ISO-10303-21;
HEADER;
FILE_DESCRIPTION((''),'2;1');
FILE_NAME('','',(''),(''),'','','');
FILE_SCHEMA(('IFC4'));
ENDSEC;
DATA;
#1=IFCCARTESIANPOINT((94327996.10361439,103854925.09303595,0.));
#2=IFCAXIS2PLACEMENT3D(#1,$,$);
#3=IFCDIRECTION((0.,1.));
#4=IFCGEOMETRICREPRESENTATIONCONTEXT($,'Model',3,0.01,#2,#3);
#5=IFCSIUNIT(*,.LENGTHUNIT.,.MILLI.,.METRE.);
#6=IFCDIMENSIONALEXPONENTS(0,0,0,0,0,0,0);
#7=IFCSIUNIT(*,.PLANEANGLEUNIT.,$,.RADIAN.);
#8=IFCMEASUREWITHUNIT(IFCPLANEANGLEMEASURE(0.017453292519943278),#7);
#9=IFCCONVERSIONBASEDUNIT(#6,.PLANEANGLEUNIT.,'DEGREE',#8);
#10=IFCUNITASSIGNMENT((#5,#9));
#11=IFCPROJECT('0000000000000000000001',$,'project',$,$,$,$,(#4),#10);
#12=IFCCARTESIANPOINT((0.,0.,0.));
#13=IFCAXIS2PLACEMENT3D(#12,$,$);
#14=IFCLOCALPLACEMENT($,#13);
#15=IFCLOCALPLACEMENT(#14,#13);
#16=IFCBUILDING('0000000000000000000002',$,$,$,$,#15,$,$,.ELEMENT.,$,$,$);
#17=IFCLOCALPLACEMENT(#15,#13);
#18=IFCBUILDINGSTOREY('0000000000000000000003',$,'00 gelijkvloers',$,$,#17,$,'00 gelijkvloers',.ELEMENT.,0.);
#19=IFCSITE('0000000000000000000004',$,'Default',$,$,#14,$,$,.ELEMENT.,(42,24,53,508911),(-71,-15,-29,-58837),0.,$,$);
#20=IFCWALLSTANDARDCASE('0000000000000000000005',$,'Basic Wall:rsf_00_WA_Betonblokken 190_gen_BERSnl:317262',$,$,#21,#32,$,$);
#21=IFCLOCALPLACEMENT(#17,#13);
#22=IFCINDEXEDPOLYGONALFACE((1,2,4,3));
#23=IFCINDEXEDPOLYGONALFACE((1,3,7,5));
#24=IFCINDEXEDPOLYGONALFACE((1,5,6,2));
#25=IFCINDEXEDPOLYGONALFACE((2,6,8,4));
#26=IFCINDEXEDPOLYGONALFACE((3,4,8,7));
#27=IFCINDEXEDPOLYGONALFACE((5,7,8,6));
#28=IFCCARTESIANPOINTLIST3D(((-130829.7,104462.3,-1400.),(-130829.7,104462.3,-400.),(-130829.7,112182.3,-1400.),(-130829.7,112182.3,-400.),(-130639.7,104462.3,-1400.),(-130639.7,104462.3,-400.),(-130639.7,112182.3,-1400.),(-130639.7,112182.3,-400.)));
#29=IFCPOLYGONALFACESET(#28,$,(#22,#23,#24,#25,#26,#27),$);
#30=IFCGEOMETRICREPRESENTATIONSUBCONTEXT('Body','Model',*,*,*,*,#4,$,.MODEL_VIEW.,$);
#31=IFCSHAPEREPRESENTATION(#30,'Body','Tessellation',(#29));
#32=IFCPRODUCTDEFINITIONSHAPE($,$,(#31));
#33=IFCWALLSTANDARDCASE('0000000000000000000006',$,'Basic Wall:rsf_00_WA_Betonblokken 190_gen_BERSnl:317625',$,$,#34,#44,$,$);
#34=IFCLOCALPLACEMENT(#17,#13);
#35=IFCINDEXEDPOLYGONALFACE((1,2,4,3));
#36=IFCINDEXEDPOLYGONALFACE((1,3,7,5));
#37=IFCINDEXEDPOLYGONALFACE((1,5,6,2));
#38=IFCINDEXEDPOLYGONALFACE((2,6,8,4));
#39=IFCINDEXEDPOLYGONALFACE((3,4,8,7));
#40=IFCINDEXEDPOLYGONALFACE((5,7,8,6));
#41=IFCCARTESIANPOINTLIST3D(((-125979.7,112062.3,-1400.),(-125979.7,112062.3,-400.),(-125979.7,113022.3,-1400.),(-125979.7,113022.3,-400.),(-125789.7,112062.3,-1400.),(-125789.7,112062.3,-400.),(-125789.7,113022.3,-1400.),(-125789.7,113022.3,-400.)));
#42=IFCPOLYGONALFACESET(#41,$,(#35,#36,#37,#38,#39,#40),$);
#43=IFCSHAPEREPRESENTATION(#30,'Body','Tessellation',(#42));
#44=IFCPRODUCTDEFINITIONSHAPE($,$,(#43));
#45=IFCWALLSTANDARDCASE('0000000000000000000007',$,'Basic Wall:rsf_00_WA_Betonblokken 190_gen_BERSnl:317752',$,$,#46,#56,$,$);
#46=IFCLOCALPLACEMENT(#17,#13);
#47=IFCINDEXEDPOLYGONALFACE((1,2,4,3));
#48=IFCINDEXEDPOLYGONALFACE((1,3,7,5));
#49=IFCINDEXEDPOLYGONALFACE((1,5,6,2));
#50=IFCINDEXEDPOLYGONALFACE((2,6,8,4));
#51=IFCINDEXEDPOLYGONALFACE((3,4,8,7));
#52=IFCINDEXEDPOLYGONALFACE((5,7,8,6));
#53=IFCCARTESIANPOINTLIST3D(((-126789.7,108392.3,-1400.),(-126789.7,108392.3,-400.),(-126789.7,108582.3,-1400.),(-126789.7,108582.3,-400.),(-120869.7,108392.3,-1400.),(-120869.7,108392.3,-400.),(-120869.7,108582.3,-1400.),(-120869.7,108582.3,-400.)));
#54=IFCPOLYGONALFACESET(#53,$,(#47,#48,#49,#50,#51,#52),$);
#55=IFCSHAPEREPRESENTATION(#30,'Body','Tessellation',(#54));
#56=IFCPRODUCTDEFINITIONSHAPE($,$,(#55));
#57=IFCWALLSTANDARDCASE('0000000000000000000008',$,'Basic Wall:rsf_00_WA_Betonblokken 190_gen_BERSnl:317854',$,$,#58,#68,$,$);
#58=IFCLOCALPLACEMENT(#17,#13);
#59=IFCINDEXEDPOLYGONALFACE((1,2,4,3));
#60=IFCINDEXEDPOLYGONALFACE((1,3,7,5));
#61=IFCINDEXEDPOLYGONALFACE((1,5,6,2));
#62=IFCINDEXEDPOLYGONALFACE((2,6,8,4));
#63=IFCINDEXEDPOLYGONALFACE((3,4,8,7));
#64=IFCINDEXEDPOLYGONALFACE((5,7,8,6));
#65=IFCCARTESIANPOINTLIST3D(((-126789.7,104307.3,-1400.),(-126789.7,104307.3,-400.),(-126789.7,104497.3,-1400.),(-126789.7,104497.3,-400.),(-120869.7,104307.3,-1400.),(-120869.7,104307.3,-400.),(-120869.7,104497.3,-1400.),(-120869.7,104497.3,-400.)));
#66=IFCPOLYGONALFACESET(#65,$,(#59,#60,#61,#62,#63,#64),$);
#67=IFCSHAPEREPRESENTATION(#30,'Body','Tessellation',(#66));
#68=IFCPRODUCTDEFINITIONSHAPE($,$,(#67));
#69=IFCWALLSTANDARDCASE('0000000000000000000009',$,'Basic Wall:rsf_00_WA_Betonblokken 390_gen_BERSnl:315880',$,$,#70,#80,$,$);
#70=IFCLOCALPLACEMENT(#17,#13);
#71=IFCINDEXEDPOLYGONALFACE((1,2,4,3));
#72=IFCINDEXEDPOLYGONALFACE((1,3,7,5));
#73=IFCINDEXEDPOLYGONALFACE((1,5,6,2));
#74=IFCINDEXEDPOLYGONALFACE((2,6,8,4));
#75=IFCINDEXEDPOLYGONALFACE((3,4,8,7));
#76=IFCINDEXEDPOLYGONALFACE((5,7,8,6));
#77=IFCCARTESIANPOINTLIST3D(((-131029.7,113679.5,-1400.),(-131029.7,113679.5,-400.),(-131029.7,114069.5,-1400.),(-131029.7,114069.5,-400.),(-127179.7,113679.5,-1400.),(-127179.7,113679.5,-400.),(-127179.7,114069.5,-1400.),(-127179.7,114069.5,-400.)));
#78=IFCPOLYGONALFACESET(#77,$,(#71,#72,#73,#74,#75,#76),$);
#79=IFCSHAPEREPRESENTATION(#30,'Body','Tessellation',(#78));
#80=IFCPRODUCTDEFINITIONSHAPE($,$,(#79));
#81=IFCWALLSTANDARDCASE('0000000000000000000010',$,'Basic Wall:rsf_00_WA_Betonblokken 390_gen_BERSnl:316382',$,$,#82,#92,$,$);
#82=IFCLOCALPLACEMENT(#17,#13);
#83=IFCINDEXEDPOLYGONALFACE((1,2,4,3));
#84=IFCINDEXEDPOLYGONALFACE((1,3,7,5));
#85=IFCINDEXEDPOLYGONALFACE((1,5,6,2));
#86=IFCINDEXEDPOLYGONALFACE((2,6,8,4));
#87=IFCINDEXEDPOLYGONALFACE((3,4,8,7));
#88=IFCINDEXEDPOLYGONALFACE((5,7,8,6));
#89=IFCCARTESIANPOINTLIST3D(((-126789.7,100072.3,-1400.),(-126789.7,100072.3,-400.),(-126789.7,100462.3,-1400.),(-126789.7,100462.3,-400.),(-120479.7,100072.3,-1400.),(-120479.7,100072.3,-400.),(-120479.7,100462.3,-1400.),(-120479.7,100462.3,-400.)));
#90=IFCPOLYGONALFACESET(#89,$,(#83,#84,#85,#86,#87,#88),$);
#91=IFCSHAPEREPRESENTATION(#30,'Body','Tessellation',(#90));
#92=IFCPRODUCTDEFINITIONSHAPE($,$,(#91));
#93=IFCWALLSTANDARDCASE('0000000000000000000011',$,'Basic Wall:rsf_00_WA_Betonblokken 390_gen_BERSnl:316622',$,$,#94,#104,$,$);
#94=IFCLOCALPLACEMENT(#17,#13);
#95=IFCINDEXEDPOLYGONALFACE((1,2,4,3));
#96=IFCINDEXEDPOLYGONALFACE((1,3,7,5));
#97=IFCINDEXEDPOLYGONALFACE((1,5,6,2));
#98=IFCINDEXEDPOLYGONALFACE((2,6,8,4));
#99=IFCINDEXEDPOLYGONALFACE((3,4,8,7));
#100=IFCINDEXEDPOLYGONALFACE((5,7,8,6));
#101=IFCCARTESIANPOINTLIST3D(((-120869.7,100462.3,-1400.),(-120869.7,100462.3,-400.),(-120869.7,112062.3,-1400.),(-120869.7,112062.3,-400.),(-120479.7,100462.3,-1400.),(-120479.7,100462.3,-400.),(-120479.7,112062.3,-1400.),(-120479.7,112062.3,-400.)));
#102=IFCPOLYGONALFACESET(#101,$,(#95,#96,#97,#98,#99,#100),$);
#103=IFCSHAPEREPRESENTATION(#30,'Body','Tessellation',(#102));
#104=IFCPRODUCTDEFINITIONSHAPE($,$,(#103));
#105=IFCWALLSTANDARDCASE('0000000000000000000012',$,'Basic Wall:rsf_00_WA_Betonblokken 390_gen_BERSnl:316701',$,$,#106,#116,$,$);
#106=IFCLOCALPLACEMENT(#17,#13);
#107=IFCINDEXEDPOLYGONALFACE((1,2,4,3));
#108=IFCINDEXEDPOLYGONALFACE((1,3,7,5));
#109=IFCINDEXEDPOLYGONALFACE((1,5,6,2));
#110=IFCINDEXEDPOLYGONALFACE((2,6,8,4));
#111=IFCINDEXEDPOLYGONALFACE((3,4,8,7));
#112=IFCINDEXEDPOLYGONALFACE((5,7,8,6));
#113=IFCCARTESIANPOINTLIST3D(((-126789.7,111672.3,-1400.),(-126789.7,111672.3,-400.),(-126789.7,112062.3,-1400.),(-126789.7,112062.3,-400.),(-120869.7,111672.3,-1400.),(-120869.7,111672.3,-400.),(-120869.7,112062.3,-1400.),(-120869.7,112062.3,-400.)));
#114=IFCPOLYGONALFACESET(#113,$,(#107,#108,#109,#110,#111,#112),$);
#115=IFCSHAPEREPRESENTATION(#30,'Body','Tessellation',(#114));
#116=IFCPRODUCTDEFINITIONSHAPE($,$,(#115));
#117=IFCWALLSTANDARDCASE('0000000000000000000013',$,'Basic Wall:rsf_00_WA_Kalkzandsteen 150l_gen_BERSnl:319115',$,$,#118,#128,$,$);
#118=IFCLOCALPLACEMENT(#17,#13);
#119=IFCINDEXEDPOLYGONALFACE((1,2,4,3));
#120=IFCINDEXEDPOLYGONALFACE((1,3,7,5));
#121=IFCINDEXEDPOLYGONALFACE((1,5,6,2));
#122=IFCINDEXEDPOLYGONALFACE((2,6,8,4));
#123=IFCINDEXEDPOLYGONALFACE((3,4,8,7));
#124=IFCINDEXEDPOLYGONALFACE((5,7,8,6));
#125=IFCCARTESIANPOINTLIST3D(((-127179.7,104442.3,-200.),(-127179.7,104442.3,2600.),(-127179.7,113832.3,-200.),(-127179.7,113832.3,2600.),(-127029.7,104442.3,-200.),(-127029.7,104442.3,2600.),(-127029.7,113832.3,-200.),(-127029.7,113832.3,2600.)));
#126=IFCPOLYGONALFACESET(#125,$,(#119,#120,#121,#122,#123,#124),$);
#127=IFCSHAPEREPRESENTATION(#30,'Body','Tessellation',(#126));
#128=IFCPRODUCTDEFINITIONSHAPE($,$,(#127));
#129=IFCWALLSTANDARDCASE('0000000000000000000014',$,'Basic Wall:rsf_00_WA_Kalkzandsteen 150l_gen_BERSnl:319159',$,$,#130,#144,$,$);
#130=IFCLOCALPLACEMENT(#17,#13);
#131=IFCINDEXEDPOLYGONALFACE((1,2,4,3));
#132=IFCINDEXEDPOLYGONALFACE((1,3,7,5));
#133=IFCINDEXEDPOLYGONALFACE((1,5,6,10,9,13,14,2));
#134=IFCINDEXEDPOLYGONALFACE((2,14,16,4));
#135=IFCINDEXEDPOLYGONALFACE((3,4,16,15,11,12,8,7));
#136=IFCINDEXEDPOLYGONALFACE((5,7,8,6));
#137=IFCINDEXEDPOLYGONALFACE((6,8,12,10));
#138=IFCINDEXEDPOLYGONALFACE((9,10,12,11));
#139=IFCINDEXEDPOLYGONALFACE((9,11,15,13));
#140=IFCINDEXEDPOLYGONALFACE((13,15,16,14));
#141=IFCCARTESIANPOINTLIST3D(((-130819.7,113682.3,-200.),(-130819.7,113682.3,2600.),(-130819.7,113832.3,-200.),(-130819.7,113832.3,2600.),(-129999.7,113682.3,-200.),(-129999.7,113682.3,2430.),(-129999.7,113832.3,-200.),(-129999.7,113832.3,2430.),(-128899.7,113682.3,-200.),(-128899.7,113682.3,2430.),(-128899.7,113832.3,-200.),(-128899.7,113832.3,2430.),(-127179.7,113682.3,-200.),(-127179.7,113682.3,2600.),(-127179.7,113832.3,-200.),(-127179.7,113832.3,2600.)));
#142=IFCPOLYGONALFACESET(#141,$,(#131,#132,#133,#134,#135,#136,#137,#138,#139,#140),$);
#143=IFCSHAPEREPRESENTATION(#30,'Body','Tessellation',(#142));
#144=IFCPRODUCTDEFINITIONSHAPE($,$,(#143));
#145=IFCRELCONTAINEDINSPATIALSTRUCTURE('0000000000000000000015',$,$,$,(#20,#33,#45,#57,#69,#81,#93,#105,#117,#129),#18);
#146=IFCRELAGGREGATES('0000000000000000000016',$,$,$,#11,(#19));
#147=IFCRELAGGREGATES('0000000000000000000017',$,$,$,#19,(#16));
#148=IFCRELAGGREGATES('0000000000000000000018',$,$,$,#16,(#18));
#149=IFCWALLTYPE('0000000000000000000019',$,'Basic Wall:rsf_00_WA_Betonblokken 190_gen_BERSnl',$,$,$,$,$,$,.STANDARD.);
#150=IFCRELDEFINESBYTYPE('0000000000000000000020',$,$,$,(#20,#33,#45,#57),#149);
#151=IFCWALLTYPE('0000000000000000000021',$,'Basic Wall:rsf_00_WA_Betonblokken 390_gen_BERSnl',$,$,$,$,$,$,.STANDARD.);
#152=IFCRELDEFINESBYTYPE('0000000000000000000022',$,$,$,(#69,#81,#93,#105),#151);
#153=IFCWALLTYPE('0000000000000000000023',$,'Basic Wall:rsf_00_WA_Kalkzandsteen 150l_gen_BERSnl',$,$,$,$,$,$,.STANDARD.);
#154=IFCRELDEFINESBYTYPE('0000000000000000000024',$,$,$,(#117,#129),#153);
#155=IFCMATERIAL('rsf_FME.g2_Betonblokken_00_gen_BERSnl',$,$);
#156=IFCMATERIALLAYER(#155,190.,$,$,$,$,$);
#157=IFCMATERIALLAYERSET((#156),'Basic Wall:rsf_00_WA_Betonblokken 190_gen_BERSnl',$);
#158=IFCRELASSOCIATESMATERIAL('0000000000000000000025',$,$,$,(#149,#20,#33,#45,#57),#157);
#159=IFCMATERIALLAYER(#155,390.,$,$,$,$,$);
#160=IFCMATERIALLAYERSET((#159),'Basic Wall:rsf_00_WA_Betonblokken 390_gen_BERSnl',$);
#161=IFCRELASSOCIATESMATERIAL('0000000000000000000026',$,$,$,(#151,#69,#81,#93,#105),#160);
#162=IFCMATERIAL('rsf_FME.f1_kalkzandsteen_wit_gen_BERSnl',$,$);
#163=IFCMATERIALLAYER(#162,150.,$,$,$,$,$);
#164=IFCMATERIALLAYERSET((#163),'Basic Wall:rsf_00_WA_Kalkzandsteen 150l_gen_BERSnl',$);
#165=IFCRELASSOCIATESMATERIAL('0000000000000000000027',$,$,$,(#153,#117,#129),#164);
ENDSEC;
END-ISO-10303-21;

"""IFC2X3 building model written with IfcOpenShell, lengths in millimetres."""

from ifc_helpers import new_model, entity, si_unit, converted_unit, direction, frame, frame_2d, origin, place, context, subcontext, project, spatial, polyline, rectangle, extrude, clip, bounded_halfspace, material, layer, layer_set, layer_usage, type_object, element, save


model = new_model("IFC2X3")

# Units and contexts
model_context = context("Model", 3, precision=0.01, world=frame((94327996.10361439, 103854925.09303595, 0.0)), true_north=direction((0.0, 1.0)))
body_context = subcontext(model_context, "Body", "Model", "MODEL_VIEW")
ifc_project = project(units=[si_unit("LENGTHUNIT", "METRE", prefix="MILLI"), converted_unit("PLANEANGLEUNIT", "DEGREE", entity("IfcPlaneAngleMeasure", 0.017453292519943278), si_unit("PLANEANGLEUNIT", "RADIAN"), dimensions=[0, 0, 0, 0, 0, 0, 0])], contexts=[model_context])

# Site, building, storey
site_placement = place(None, origin())
site = spatial("IfcSite", under=ifc_project, at=site_placement, Name="Default", CompositionType="ELEMENT", RefLatitude=(42, 24, 53, 508911), RefLongitude=(-71, -15, -29, -58837), RefElevation=0.0)
building_placement = place(site_placement, origin())
building = spatial("IfcBuilding", under=site, at=building_placement, CompositionType="ELEMENT")
storey_placement = place(building_placement, origin())
storey = spatial("IfcBuildingStorey", under=building, at=storey_placement, Name="00 gelijkvloers", LongName="00 gelijkvloers", CompositionType="ELEMENT", Elevation=0.0)

# Walls
ifc_material_1 = material(Name="rsf_FME.g2_Betonblokken_00_gen_BERSnl")
ifc_layer_1 = layer(ifc_material_1, 190.0)
ifc_layer_set_1 = layer_set([ifc_layer_1], Name="Basic Wall:rsf_00_WA_Betonblokken 190_gen_BERSnl")
ifc_layer_usage_1 = layer_usage(ifc_layer_set_1, "AXIS2", "POSITIVE", -95.0)
wall_type_1 = type_object("IfcWallType", Name="Basic Wall:rsf_00_WA_Betonblokken 190_gen_BERSnl", PredefinedType="STANDARD", material=ifc_layer_set_1)
wall_1_placement = place(storey_placement, frame((-130734.7, 104462.3, -1400.0), z_axis=(0.0, 0.0, 1.0), x_axis=(0.0, 1.0, 0.0)))
element("IfcWallStandardCase", 1, at=wall_1_placement, inside=storey, type_object=wall_type_1, material=ifc_layer_usage_1, Name="Basic Wall:rsf_00_WA_Betonblokken 190_gen_BERSnl:317262", context=body_context, shape_type="Clipping", body=[
    clip(extrude(rectangle(XDim=7720.0, YDim=190.0, at=frame_2d((3860.0, 0.0), x_axis=(-1.0, 0.0))), origin(), (0.0, 0.0, 1.0), 1000.0), bounded_halfspace(frame((0.0, -95.0, 1000.0), z_axis=(0.0, 0.0, -1.0), x_axis=(1.0, 0.0, 0.0)), True, frame((0.0, -95.0, 1000.0)), polyline([(0.0, 0.0), (7720.0, 0.0), (7720.0, 190.0), (0.0, 190.0), (0.0, 0.0)]))),
])
ifc_layer_usage_2 = layer_usage(ifc_layer_set_1, "AXIS2", "POSITIVE", -95.0)
wall_2_placement = place(storey_placement, frame((-125884.7, 112062.3, -1400.0), z_axis=(0.0, 0.0, 1.0), x_axis=(0.0, 1.0, 0.0)))
element("IfcWallStandardCase", 2, at=wall_2_placement, inside=storey, type_object=wall_type_1, material=ifc_layer_usage_2, Name="Basic Wall:rsf_00_WA_Betonblokken 190_gen_BERSnl:317625", context=body_context, shape_type="Clipping", body=[
    clip(extrude(rectangle(XDim=960.0, YDim=190.0, at=frame_2d((480.0, 0.0), x_axis=(-1.0, 0.0))), origin(), (0.0, 0.0, 1.0), 1000.0), bounded_halfspace(frame((0.0, -95.0, 1000.0), z_axis=(0.0, 0.0, -1.0), x_axis=(1.0, 0.0, 0.0)), True, frame((0.0, -95.0, 1000.0)), polyline([(0.0, 0.0), (960.0, 0.0), (960.0, 190.0), (0.0, 190.0), (0.0, 0.0)]))),
])
ifc_layer_usage_3 = layer_usage(ifc_layer_set_1, "AXIS2", "NEGATIVE", 95.0)
wall_3_placement = place(storey_placement, frame((-126789.7, 108487.3, -1400.0)))
element("IfcWallStandardCase", 3, at=wall_3_placement, inside=storey, type_object=wall_type_1, material=ifc_layer_usage_3, Name="Basic Wall:rsf_00_WA_Betonblokken 190_gen_BERSnl:317752", context=body_context, shape_type="Clipping", body=[
    clip(extrude(rectangle(XDim=5920.0, YDim=190.0, at=frame_2d((2960.0, 0.0), x_axis=(-1.0, 0.0))), origin(), (0.0, 0.0, 1.0), 1000.0), bounded_halfspace(frame((0.0, -95.0, 1000.0), z_axis=(0.0, 0.0, -1.0), x_axis=(0.0, 1.0, 0.0)), True, frame((0.0, -95.0, 1000.0)), polyline([(0.0, 0.0), (5920.0, 0.0), (5920.0, 190.0), (0.0, 190.0), (0.0, 0.0)]))),
])
ifc_layer_usage_4 = layer_usage(ifc_layer_set_1, "AXIS2", "NEGATIVE", 95.0)
wall_4_placement = place(storey_placement, frame((-126789.7, 104402.3, -1400.0)))
element("IfcWallStandardCase", 4, at=wall_4_placement, inside=storey, type_object=wall_type_1, material=ifc_layer_usage_4, Name="Basic Wall:rsf_00_WA_Betonblokken 190_gen_BERSnl:317854", context=body_context, shape_type="Clipping", body=[
    clip(extrude(rectangle(XDim=5920.0, YDim=190.0, at=frame_2d((2960.0, 0.0), x_axis=(-1.0, 0.0))), origin(), (0.0, 0.0, 1.0), 1000.0), bounded_halfspace(frame((0.0, -95.0, 1000.0), z_axis=(0.0, 0.0, -1.0), x_axis=(0.0, 1.0, 0.0)), True, frame((0.0, -95.0, 1000.0)), polyline([(0.0, 0.0), (5920.0, 0.0), (5920.0, 190.0), (0.0, 190.0), (0.0, 0.0)]))),
])
ifc_layer_2 = layer(ifc_material_1, 390.0)
ifc_layer_set_2 = layer_set([ifc_layer_2], Name="Basic Wall:rsf_00_WA_Betonblokken 390_gen_BERSnl")
wall_type_2 = type_object("IfcWallType", Name="Basic Wall:rsf_00_WA_Betonblokken 390_gen_BERSnl", PredefinedType="STANDARD", material=ifc_layer_set_2)
ifc_layer_usage_5 = layer_usage(ifc_layer_set_2, "AXIS2", "POSITIVE", -195.0)
wall_5_placement = place(storey_placement, frame((-127179.7, 113874.5, -1400.0), z_axis=(0.0, 0.0, 1.0), x_axis=(-1.0, 0.0, 0.0)))
element("IfcWallStandardCase", 5, at=wall_5_placement, inside=storey, type_object=wall_type_2, material=ifc_layer_usage_5, Name="Basic Wall:rsf_00_WA_Betonblokken 390_gen_BERSnl:315880", context=body_context, shape_type="Clipping", body=[
    clip(extrude(rectangle(XDim=3850.0, YDim=390.0, at=frame_2d((1925.0, 0.0), x_axis=(-1.0, 0.0))), origin(), (0.0, 0.0, 1.0), 1000.0), bounded_halfspace(frame((0.0, -195.0, 1000.0), z_axis=(0.0, 0.0, -1.0), x_axis=(0.0, -1.0, 0.0)), True, frame((0.0, -195.0, 1000.0)), polyline([(0.0, 0.0), (3660.0, 0.0), (3850.0, 0.0), (3850.0, 390.0), (3460.0, 390.0), (0.0, 390.0), (0.0, 0.0)]))),
])
ifc_layer_usage_6 = layer_usage(ifc_layer_set_2, "AXIS2", "NEGATIVE", 195.0)
wall_6_placement = place(storey_placement, frame((-126789.7, 100267.3, -1400.0)))
element("IfcWallStandardCase", 6, at=wall_6_placement, inside=storey, type_object=wall_type_2, material=ifc_layer_usage_6, Name="Basic Wall:rsf_00_WA_Betonblokken 390_gen_BERSnl:316382", context=body_context, shape_type="Clipping", body=[
    clip(extrude(rectangle(XDim=6310.0, YDim=390.0, at=frame_2d((3155.0, 0.0), x_axis=(-1.0, 0.0))), origin(), (0.0, 0.0, 1.0), 1000.0), bounded_halfspace(frame((0.0, -195.0, 1000.0), z_axis=(0.0, 0.0, -1.0), x_axis=(0.0, 1.0, 0.0)), True, frame((0.0, -195.0, 1000.0)), polyline([(0.0, 0.0), (6310.0, 0.0), (6310.0, 390.0), (5920.0, 390.0), (0.0, 390.0), (0.0, 0.0)]))),
])
ifc_layer_usage_7 = layer_usage(ifc_layer_set_2, "AXIS2", "POSITIVE", -195.0)
wall_7_placement = place(storey_placement, frame((-120674.7, 100462.3, -1400.0), z_axis=(0.0, 0.0, 1.0), x_axis=(0.0, 1.0, 0.0)))
element("IfcWallStandardCase", 7, at=wall_7_placement, inside=storey, type_object=wall_type_2, material=ifc_layer_usage_7, Name="Basic Wall:rsf_00_WA_Betonblokken 390_gen_BERSnl:316622", context=body_context, shape_type="Clipping", body=[
    clip(extrude(rectangle(XDim=11600.0, YDim=390.0, at=frame_2d((5800.0, 0.0), x_axis=(-1.0, 0.0))), origin(), (0.0, 0.0, 1.0), 1000.0), bounded_halfspace(frame((0.0, -195.0, 1000.0), z_axis=(0.0, 0.0, -1.0), x_axis=(1.0, 0.0, 0.0)), True, frame((0.0, -195.0, 1000.0)), polyline([(0.0, 0.0), (11600.0, 0.0), (11600.0, 390.0), (11210.0, 390.0), (8120.0, 390.0), (7930.0, 390.0), (4035.0, 390.0), (3845.0, 390.0), (0.0, 390.0), (0.0, 0.0)]))),
])
ifc_layer_usage_8 = layer_usage(ifc_layer_set_2, "AXIS2", "POSITIVE", -195.0)
wall_8_placement = place(storey_placement, frame((-120869.7, 111867.3, -1400.0), z_axis=(0.0, 0.0, 1.0), x_axis=(-1.0, 0.0, 0.0)))
element("IfcWallStandardCase", 8, at=wall_8_placement, inside=storey, type_object=wall_type_2, material=ifc_layer_usage_8, Name="Basic Wall:rsf_00_WA_Betonblokken 390_gen_BERSnl:316701", context=body_context, shape_type="Clipping", body=[
    clip(extrude(rectangle(XDim=5920.0, YDim=390.0, at=frame_2d((2960.0, 0.0), x_axis=(-1.0, 0.0))), origin(), (0.0, 0.0, 1.0), 1000.0), bounded_halfspace(frame((0.0, -195.0, 1000.0), z_axis=(0.0, 0.0, -1.0), x_axis=(0.0, -1.0, 0.0)), True, frame((0.0, -195.0, 1000.0)), polyline([(0.0, 0.0), (4920.0, 0.0), (5110.0, 0.0), (5920.0, 0.0), (5920.0, 390.0), (0.0, 390.0), (0.0, 0.0)]))),
])
ifc_material_2 = material(Name="rsf_FME.f1_kalkzandsteen_wit_gen_BERSnl")
ifc_layer_3 = layer(ifc_material_2, 150.0)
ifc_layer_set_3 = layer_set([ifc_layer_3], Name="Basic Wall:rsf_00_WA_Kalkzandsteen 150l_gen_BERSnl")
ifc_layer_usage_9 = layer_usage(ifc_layer_set_3, "AXIS2", "POSITIVE", -75.0)
wall_type_3 = type_object("IfcWallType", Name="Basic Wall:rsf_00_WA_Kalkzandsteen 150l_gen_BERSnl", PredefinedType="STANDARD", material=ifc_layer_set_3)
wall_9_placement = place(storey_placement, frame((-127104.7, 104442.3, -200.0), z_axis=(0.0, 0.0, 1.0), x_axis=(0.0, 1.0, 0.0)))
element("IfcWallStandardCase", 9, at=wall_9_placement, inside=storey, type_object=wall_type_3, material=ifc_layer_usage_9, Name="Basic Wall:rsf_00_WA_Kalkzandsteen 150l_gen_BERSnl:319115", context=body_context, shape_type="Clipping", body=[
    clip(extrude(rectangle(XDim=9390.0, YDim=150.0, at=frame_2d((4695.0, 0.0), x_axis=(-1.0, 0.0))), origin(), (0.0, 0.0, 1.0), 2800.0), bounded_halfspace(frame((0.0, -75.0, 2800.0), z_axis=(0.0, 0.0, -1.0), x_axis=(1.0, 0.0, 0.0)), True, frame((0.0, -75.0, 2800.0)), polyline([(0.0, 0.0), (7390.0, 0.0), (9390.0, 0.0), (9390.0, 150.0), (9240.0, 150.0), (0.0, 150.0), (0.0, 0.0)]))),
])

# Wall, opening
ifc_layer_usage_10 = layer_usage(ifc_layer_set_3, "AXIS2", "POSITIVE", -75.0)
wall_10_placement = place(storey_placement, frame((-127179.7, 113757.3, -200.0), z_axis=(0.0, 0.0, 1.0), x_axis=(-1.0, 0.0, 0.0)))
wall_10 = element("IfcWallStandardCase", 10, at=wall_10_placement, inside=storey, type_object=wall_type_3, material=ifc_layer_usage_10, Name="Basic Wall:rsf_00_WA_Kalkzandsteen 150l_gen_BERSnl:319159", context=body_context, shape_type="Clipping", body=[
    clip(extrude(rectangle(XDim=3640.0, YDim=150.0, at=frame_2d((1820.0, 0.0), x_axis=(-1.0, 0.0))), origin(), (0.0, 0.0, 1.0), 2800.0), bounded_halfspace(frame((0.0, -75.0, 2800.0), z_axis=(0.0, 0.0, -1.0), x_axis=(0.0, -1.0, 0.0)), True, frame((0.0, -75.0, 2800.0)), polyline([(0.0, 0.0), (3640.0, 0.0), (3640.0, 150.0), (3490.0, 150.0), (0.0, 150.0), (0.0, 0.0)]))),
])
opening_1_placement = place(wall_10_placement, frame((-127179.7, 113757.3, 200.0), z_axis=(0.0, 0.0, 1.0), x_axis=(-1.0, 0.0, 0.0)))
element("IfcOpeningElement", 11, at=opening_1_placement, cuts=wall_10, ObjectType="Opening", context=body_context, shape_type="SweptSolid", body=[
    extrude(rectangle(XDim=2630.0, YDim=1100.0, at=frame_2d((0.0, 0.0), x_axis=(0.0, 1.0))), frame((-129449.7, 115356.3, 1115.0), z_axis=(0.0, -1.0, 0.0), x_axis=(1.0, 0.0, 0.0)), (0.0, 0.0, 1.0), 3048.0),
])

save(model, "model.ifc")
